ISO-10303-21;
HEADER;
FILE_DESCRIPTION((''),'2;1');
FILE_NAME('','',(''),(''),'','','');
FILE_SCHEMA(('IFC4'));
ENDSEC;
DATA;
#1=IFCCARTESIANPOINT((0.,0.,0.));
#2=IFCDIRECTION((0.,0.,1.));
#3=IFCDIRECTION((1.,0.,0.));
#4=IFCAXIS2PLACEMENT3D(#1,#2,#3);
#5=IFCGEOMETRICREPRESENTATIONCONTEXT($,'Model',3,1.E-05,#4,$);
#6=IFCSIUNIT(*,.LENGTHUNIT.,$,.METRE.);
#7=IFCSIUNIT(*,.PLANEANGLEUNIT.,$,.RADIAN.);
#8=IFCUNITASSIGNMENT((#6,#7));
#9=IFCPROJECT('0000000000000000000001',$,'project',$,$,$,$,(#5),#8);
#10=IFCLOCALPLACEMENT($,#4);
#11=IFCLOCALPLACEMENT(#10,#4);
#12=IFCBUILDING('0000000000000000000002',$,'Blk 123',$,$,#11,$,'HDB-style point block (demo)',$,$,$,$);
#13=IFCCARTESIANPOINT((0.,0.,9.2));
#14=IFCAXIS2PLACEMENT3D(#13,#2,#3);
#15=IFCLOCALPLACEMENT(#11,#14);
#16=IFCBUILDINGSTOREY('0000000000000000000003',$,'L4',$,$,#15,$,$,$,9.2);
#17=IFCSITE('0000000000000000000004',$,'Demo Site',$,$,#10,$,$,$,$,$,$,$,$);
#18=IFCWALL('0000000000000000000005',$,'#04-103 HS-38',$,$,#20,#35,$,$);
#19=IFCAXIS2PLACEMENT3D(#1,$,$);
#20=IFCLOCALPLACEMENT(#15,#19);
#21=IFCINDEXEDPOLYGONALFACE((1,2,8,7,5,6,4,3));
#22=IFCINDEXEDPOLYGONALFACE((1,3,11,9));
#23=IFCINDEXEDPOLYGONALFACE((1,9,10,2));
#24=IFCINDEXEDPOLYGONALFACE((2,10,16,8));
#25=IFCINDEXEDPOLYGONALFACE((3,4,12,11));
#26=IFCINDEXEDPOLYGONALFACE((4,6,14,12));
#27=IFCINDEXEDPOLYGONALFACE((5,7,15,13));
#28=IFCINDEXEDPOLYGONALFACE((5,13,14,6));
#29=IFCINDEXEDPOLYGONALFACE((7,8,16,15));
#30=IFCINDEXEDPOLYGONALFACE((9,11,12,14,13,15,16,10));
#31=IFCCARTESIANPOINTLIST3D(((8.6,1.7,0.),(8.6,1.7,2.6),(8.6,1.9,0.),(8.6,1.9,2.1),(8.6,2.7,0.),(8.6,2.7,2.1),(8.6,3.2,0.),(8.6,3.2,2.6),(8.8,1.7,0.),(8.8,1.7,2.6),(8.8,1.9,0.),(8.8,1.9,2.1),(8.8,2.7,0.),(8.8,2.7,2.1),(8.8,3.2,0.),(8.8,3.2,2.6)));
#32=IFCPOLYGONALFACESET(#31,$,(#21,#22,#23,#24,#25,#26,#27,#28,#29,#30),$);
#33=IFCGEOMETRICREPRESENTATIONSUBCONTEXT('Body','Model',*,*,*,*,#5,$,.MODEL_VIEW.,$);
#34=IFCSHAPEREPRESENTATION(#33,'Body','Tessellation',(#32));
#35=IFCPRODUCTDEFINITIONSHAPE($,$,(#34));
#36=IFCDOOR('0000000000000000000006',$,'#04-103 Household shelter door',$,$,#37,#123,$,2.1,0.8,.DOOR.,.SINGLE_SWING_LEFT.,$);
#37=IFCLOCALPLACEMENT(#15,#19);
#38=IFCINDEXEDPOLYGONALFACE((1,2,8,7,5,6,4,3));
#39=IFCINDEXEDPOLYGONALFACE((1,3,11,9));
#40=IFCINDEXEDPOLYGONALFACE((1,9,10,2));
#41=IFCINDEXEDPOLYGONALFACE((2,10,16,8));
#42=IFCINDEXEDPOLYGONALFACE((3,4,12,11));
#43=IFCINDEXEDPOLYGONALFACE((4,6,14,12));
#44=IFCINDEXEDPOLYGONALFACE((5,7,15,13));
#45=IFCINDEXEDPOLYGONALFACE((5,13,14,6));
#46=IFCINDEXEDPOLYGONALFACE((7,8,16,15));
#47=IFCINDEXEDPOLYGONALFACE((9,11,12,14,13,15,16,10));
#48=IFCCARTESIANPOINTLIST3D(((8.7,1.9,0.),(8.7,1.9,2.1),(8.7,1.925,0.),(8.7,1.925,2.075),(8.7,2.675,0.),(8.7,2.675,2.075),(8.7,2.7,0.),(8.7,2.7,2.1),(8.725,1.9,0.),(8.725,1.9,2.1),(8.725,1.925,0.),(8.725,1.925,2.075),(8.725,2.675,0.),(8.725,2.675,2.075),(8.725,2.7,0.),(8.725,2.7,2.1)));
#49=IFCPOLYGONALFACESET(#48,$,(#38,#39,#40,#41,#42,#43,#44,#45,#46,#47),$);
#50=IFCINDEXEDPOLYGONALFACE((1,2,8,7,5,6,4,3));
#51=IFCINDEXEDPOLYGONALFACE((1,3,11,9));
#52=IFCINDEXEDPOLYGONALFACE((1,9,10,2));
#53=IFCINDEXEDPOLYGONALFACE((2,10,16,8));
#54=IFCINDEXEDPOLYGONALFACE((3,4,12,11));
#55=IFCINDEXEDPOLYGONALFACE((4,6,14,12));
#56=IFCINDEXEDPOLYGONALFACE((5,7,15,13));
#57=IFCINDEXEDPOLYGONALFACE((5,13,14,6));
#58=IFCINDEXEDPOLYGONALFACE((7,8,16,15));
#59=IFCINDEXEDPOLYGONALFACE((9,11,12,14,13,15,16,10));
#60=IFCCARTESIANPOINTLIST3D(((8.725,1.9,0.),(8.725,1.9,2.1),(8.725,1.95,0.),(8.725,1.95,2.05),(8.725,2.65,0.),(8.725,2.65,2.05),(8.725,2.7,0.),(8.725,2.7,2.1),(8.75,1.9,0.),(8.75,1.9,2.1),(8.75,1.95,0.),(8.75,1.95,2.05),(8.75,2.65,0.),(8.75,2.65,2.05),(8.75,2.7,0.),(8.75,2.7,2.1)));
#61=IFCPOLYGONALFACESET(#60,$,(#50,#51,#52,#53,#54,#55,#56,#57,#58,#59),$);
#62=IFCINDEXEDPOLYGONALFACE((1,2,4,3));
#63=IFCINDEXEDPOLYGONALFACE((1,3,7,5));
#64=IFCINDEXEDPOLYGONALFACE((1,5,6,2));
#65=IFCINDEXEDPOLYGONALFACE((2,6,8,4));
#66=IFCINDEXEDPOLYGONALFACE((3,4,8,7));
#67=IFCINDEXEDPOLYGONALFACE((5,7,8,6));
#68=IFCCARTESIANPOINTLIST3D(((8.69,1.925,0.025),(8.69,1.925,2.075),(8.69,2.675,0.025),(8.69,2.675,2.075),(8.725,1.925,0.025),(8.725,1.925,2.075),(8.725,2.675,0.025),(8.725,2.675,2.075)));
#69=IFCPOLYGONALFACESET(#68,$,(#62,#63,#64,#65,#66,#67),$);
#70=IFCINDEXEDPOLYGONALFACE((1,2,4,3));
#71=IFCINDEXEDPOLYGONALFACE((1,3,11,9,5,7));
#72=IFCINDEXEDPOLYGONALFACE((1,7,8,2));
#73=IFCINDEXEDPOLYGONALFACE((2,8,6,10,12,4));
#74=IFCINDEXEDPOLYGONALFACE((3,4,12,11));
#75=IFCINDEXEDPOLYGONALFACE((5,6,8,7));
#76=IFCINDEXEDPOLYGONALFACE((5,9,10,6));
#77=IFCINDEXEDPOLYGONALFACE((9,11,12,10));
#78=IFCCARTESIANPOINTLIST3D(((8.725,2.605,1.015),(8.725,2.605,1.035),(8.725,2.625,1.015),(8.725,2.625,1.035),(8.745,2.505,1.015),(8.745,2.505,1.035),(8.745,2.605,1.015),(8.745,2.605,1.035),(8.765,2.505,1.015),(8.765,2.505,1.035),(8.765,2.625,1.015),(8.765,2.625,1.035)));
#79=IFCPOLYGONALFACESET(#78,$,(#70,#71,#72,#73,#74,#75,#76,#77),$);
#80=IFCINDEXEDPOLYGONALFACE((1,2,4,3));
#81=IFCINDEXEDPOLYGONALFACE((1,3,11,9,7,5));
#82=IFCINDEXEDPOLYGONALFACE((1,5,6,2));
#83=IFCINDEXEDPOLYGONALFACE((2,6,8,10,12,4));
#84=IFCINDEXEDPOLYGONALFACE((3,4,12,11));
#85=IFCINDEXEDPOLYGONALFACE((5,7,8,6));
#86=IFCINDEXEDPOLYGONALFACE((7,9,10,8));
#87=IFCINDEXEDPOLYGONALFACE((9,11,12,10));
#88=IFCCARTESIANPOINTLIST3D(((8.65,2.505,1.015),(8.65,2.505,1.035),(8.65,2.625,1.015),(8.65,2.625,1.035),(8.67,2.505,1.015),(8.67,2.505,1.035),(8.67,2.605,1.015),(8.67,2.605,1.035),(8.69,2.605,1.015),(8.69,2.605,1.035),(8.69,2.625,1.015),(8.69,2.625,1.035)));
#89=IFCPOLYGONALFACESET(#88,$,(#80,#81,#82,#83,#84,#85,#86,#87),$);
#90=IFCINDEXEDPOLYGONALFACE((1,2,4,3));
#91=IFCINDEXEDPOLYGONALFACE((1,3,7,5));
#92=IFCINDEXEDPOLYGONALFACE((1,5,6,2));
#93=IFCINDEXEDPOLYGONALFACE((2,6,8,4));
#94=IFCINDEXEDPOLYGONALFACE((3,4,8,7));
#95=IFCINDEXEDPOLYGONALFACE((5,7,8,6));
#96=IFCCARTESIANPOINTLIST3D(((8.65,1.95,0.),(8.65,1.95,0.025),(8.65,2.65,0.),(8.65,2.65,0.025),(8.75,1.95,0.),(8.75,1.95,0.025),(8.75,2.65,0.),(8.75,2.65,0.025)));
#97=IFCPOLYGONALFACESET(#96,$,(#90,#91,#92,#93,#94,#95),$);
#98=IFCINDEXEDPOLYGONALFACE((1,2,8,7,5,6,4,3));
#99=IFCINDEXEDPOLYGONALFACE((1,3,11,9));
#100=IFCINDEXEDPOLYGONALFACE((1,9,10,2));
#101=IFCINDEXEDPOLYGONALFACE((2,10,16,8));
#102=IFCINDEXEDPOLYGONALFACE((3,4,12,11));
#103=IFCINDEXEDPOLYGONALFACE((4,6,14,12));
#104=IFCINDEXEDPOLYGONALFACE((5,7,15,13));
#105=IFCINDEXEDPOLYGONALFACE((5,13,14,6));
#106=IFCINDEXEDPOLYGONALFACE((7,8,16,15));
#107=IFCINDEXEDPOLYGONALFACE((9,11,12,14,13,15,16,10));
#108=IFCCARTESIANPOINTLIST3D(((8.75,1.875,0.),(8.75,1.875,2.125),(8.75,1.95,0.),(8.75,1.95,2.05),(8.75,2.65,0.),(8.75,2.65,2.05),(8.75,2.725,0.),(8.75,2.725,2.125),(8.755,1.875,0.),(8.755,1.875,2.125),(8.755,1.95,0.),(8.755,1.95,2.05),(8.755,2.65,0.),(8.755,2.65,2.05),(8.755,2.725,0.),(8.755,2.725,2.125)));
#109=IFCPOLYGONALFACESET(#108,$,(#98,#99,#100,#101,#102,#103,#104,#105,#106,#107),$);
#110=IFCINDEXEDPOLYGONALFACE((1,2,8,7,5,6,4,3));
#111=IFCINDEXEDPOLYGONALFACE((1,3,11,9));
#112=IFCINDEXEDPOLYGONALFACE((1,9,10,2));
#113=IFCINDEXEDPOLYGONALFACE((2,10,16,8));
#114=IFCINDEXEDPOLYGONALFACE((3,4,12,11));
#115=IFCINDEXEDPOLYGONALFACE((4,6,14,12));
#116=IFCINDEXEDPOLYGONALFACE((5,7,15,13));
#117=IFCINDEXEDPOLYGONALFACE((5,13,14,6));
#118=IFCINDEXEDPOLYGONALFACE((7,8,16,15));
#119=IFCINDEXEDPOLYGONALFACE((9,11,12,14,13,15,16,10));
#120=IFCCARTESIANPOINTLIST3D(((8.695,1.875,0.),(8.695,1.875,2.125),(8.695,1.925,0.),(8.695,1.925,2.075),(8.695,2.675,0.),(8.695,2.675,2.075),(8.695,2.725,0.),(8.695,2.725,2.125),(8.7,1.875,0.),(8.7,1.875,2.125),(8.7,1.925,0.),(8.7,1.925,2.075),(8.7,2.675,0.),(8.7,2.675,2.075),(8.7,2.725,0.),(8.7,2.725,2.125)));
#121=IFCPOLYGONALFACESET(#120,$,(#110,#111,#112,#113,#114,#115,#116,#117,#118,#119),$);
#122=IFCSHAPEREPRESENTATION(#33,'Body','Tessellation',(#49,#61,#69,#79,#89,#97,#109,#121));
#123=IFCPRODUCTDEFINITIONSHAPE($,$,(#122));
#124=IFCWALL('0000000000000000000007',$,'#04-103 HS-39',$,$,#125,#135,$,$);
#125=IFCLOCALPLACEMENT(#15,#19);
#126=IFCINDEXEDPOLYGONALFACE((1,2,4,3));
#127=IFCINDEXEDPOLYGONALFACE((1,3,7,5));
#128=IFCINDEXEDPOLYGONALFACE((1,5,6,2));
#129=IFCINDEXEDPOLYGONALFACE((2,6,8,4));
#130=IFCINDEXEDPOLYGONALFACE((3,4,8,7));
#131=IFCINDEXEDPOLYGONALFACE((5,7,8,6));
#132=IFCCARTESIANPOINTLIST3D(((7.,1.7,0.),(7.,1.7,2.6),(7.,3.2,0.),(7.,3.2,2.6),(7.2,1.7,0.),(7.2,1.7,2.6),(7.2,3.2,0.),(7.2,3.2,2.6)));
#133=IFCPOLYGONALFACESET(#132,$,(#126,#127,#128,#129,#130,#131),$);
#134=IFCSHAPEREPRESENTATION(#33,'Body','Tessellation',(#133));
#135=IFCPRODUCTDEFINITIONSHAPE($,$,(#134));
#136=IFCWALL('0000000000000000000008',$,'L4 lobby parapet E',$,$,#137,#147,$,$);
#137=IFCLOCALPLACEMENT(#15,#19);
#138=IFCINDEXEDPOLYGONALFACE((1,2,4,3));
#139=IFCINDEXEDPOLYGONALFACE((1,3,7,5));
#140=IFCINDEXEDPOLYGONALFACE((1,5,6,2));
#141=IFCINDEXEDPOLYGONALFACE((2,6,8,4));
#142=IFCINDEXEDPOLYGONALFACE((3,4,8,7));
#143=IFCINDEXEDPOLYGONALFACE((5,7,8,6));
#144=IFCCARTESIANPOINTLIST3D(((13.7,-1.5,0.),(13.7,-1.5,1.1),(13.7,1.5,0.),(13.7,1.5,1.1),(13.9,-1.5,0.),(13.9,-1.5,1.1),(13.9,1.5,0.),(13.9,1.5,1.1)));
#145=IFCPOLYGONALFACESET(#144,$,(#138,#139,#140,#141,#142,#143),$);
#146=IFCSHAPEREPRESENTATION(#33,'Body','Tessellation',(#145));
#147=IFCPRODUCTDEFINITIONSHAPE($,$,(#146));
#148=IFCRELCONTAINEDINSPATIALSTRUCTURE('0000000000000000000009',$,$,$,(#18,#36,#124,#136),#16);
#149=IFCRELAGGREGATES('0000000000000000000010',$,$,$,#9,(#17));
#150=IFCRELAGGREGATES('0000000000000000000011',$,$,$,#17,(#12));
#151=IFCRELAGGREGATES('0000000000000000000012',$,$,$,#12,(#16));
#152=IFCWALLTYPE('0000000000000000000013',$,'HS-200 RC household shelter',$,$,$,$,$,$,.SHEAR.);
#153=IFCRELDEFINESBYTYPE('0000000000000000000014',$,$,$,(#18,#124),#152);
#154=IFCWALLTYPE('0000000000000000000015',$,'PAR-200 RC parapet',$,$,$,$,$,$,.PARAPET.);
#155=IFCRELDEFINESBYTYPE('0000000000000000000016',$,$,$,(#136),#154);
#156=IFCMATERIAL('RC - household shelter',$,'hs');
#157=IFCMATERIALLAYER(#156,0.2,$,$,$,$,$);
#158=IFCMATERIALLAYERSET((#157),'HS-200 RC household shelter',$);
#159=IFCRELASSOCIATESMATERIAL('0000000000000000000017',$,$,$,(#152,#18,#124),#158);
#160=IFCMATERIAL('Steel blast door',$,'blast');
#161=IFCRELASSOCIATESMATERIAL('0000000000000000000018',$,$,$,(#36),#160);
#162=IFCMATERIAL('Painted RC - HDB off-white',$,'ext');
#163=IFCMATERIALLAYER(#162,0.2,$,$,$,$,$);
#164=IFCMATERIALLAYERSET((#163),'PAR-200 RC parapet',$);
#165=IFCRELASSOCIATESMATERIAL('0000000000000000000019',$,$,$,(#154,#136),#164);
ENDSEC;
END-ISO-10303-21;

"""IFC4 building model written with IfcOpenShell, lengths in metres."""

from ifc_helpers import new_model, si_unit, frame, origin_with_axes, place, context, subcontext, project, spatial, line, indexed_curve, outline, extrude, material, layer, layer_set, layer_usage, type_object, element, fill, save


model = new_model("IFC4")

# Units and contexts
model_context = context("Model", 3, precision=1e-05, world=origin_with_axes())
body_context = subcontext(model_context, "Body", "Model", "MODEL_VIEW")
ifc_project = project(units=[si_unit("LENGTHUNIT", "METRE"), si_unit("PLANEANGLEUNIT", "RADIAN")], contexts=[model_context])

# Site, building, storey
site_placement = place(None, origin_with_axes())
site = spatial("IfcSite", under=ifc_project, at=site_placement, Name="Demo Site")
building_placement = place(site_placement, origin_with_axes())
building = spatial("IfcBuilding", under=site, at=building_placement, Name="Blk 123", LongName="HDB-style point block (demo)")
storey_placement = place(building_placement, frame((0.0, 0.0, 9.2), z_axis=(0.0, 0.0, 1.0), x_axis=(1.0, 0.0, 0.0)))
storey = spatial("IfcBuildingStorey", under=building, at=storey_placement, Name="L4", Elevation=9.2)

# Shared definitions
ifc_material_1 = material(Name="Painted RC - HDB off-white", Category="ext")

# Wall, opening, door
ifc_material_2 = material(Name="RC - household shelter", Category="hs")
ifc_layer_1 = layer(ifc_material_2, 0.2)
ifc_layer_set_1 = layer_set([ifc_layer_1], Name="HS-200 RC household shelter")
ifc_layer_usage_1 = layer_usage(ifc_layer_set_1, "AXIS2", "POSITIVE", -0.1)
wall_type_1 = type_object("IfcWallType", Name="HS-200 RC household shelter", PredefinedType="SHEAR", material=ifc_layer_set_1)
wall_1_placement = place(storey_placement, frame((8.7, 1.7, 0.0), z_axis=(0.0, 0.0, 1.0), x_axis=(0.0, 1.0, 0.0)))
wall_1 = element("IfcWall", 1, at=wall_1_placement, inside=storey, type_object=wall_type_1, material=ifc_layer_usage_1, Name="#04-103 HS-38", context=body_context, shape_type="SweptSolid", body=[
    extrude(outline(indexed_curve([(0.0, 0.0), (0.0, 0.2), (1.5, 0.2), (1.5, 0.0), (0.0, 0.0)], self_intersect=False)), frame((0.0, -0.1, 0.0), z_axis=(0.0, 0.0, 1.0), x_axis=(1.0, 0.0, 0.0)), (0.0, 0.0, 1.0), 2.6),
])
opening_1_placement = place(wall_1_placement, frame((0.2, -0.2, 0.0), z_axis=(0.0, 0.0, 1.0), x_axis=(1.0, 0.0, 0.0)))
opening_1 = element("IfcOpeningElement", 2, at=opening_1_placement, cuts=wall_1, context=body_context, shape_type="SweptSolid", body=[
    extrude(outline(indexed_curve([(0.0, 0.0), (0.0, 0.4), (0.8, 0.4), (0.8, 0.0), (0.0, 0.0)], self_intersect=False)), origin_with_axes(), (0.0, 0.0, 1.0), 2.1),
])
ifc_material_3 = material(Name="Steel blast door", Category="blast")
door_1_placement = place(opening_1_placement, frame((0.0, 0.15, 0.0), z_axis=(0.0, 0.0, 1.0), x_axis=(1.0, 0.0, 0.0)))
door_1 = element("IfcDoor", 3, at=door_1_placement, inside=storey, material=ifc_material_3, Name="#04-103 Household shelter door", OperationType="SINGLE_SWING_LEFT", OverallHeight=2.1, OverallWidth=0.8, PredefinedType="DOOR", context=body_context, shape_type="SweptSolid", body=[
    extrude(outline(indexed_curve([(0.0, 0.0), (0.0, 2.1), (0.8, 2.1), (0.8, 0.0), (0.775, 0.0), (0.775, 2.075), (0.025, 2.075), (0.025, 0.0)], segments=[line(1, 2, 3, 4, 5, 6, 7, 8, 1)])), frame((0.0, 0.025, 0.0), z_axis=(0.0, -1.0, 0.0), x_axis=(1.0, 0.0, 0.0)), (0.0, 0.0, -1.0), 0.025),
    extrude(outline(indexed_curve([(0.0, 0.0), (0.0, 2.1), (0.8, 2.1), (0.8, 0.0), (0.75, 0.0), (0.75, 2.05), (0.05, 2.05), (0.05, 0.0)], segments=[line(1, 2, 3, 4, 5, 6, 7, 8, 1)])), frame((0.0, 0.0, 0.0), z_axis=(0.0, -1.0, 0.0), x_axis=(1.0, 0.0, 0.0)), (0.0, 0.0, -1.0), 0.025),
    extrude(outline(indexed_curve([(0.0, 0.0), (0.75, 0.0), (0.75, 0.035), (0.0, 0.035)], segments=[line(1, 2, 3, 4, 1)])), frame((0.025, 0.025, 0.025), z_axis=(0.0, 0.0, 1.0), x_axis=(1.0, 0.0, 0.0)), (0.0, 0.0, 1.0), 2.05),
    extrude(outline(indexed_curve([(0.0, 0.0), (0.0, -0.04), (-0.12, -0.04), (-0.12, -0.02), (-0.02, -0.02), (-0.02, 0.0)], segments=[line(1, 2, 3, 4, 5, 6, 1)])), frame((0.725, 0.025, 1.015), z_axis=(0.0, 0.0, 1.0), x_axis=(1.0, 0.0, 0.0)), (0.0, 0.0, 1.0), 0.02),
    extrude(outline(indexed_curve([(0.0, 0.0), (0.0, 0.04), (-0.12, 0.04), (-0.12, 0.02), (-0.02, 0.02), (-0.02, 0.0)], segments=[line(1, 2, 3, 4, 5, 6, 1)])), frame((0.725, 0.06, 1.015), z_axis=(0.0, 0.0, 1.0), x_axis=(1.0, 0.0, 0.0)), (0.0, 0.0, 1.0), 0.02),
    extrude(outline(indexed_curve([(0.0, 0.0), (0.7, 0.0), (0.7, 0.1), (0.0, 0.1)], segments=[line(1, 2, 3, 4, 1)])), frame((0.05, 0.0, 0.0), z_axis=(0.0, 0.0, 1.0), x_axis=(1.0, 0.0, 0.0)), (0.0, 0.0, 1.0), 0.025),
    extrude(outline(indexed_curve([(0.0, 0.0), (0.0, 2.125), (0.85, 2.125), (0.85, 0.0), (0.775, 0.0), (0.775, 2.05), (0.075, 2.05), (0.075, 0.0)], segments=[line(1, 2, 3, 4, 5, 6, 7, 8, 1)])), frame((-0.025, -0.005, 0.0), z_axis=(0.0, -1.0, 0.0), x_axis=(1.0, 0.0, 0.0)), (0.0, 0.0, -1.0), 0.005),
    extrude(outline(indexed_curve([(0.0, 0.0), (0.0, 2.125), (0.85, 2.125), (0.85, 0.0), (0.8, 0.0), (0.8, 2.075), (0.05, 2.075), (0.05, 0.0)], segments=[line(1, 2, 3, 4, 5, 6, 7, 8, 1)])), frame((-0.025, 0.05, 0.0), z_axis=(0.0, -1.0, 0.0), x_axis=(1.0, 0.0, 0.0)), (0.0, 0.0, -1.0), 0.005),
])
fill(opening_1, door_1)

# Walls
wall_2_placement = place(storey_placement, frame((7.1, 1.7, 0.0), z_axis=(0.0, 0.0, 1.0), x_axis=(0.0, 1.0, 0.0)))
element("IfcWall", 4, at=wall_2_placement, inside=storey, type_object=wall_type_1, material=ifc_layer_usage_1, Name="#04-103 HS-39", context=body_context, shape_type="SweptSolid", body=[
    extrude(outline(indexed_curve([(0.0, 0.0), (0.0, 0.2), (1.5, 0.2), (1.5, 0.0), (0.0, 0.0)], self_intersect=False)), frame((0.0, -0.1, 0.0), z_axis=(0.0, 0.0, 1.0), x_axis=(1.0, 0.0, 0.0)), (0.0, 0.0, 1.0), 2.6),
])
ifc_layer_2 = layer(ifc_material_1, 0.2)
ifc_layer_set_2 = layer_set([ifc_layer_2], Name="PAR-200 RC parapet")
ifc_layer_usage_2 = layer_usage(ifc_layer_set_2, "AXIS2", "POSITIVE", 0.0)
wall_type_2 = type_object("IfcWallType", Name="PAR-200 RC parapet", PredefinedType="PARAPET", material=ifc_layer_set_2)
wall_3_placement = place(storey_placement, frame((13.9, -1.5, 0.0), z_axis=(0.0, 0.0, 1.0), x_axis=(0.0, 1.0, 0.0)))
element("IfcWall", 5, at=wall_3_placement, inside=storey, type_object=wall_type_2, material=ifc_layer_usage_2, Name="L4 lobby parapet E", context=body_context, shape_type="SweptSolid", body=[
    extrude(outline(indexed_curve([(0.0, 0.0), (0.0, 0.2), (3.0, 0.2), (3.0, 0.0), (0.0, 0.0)], self_intersect=False)), origin_with_axes(), (0.0, 0.0, 1.0), 1.1),
])

save(model, "model.ifc")
